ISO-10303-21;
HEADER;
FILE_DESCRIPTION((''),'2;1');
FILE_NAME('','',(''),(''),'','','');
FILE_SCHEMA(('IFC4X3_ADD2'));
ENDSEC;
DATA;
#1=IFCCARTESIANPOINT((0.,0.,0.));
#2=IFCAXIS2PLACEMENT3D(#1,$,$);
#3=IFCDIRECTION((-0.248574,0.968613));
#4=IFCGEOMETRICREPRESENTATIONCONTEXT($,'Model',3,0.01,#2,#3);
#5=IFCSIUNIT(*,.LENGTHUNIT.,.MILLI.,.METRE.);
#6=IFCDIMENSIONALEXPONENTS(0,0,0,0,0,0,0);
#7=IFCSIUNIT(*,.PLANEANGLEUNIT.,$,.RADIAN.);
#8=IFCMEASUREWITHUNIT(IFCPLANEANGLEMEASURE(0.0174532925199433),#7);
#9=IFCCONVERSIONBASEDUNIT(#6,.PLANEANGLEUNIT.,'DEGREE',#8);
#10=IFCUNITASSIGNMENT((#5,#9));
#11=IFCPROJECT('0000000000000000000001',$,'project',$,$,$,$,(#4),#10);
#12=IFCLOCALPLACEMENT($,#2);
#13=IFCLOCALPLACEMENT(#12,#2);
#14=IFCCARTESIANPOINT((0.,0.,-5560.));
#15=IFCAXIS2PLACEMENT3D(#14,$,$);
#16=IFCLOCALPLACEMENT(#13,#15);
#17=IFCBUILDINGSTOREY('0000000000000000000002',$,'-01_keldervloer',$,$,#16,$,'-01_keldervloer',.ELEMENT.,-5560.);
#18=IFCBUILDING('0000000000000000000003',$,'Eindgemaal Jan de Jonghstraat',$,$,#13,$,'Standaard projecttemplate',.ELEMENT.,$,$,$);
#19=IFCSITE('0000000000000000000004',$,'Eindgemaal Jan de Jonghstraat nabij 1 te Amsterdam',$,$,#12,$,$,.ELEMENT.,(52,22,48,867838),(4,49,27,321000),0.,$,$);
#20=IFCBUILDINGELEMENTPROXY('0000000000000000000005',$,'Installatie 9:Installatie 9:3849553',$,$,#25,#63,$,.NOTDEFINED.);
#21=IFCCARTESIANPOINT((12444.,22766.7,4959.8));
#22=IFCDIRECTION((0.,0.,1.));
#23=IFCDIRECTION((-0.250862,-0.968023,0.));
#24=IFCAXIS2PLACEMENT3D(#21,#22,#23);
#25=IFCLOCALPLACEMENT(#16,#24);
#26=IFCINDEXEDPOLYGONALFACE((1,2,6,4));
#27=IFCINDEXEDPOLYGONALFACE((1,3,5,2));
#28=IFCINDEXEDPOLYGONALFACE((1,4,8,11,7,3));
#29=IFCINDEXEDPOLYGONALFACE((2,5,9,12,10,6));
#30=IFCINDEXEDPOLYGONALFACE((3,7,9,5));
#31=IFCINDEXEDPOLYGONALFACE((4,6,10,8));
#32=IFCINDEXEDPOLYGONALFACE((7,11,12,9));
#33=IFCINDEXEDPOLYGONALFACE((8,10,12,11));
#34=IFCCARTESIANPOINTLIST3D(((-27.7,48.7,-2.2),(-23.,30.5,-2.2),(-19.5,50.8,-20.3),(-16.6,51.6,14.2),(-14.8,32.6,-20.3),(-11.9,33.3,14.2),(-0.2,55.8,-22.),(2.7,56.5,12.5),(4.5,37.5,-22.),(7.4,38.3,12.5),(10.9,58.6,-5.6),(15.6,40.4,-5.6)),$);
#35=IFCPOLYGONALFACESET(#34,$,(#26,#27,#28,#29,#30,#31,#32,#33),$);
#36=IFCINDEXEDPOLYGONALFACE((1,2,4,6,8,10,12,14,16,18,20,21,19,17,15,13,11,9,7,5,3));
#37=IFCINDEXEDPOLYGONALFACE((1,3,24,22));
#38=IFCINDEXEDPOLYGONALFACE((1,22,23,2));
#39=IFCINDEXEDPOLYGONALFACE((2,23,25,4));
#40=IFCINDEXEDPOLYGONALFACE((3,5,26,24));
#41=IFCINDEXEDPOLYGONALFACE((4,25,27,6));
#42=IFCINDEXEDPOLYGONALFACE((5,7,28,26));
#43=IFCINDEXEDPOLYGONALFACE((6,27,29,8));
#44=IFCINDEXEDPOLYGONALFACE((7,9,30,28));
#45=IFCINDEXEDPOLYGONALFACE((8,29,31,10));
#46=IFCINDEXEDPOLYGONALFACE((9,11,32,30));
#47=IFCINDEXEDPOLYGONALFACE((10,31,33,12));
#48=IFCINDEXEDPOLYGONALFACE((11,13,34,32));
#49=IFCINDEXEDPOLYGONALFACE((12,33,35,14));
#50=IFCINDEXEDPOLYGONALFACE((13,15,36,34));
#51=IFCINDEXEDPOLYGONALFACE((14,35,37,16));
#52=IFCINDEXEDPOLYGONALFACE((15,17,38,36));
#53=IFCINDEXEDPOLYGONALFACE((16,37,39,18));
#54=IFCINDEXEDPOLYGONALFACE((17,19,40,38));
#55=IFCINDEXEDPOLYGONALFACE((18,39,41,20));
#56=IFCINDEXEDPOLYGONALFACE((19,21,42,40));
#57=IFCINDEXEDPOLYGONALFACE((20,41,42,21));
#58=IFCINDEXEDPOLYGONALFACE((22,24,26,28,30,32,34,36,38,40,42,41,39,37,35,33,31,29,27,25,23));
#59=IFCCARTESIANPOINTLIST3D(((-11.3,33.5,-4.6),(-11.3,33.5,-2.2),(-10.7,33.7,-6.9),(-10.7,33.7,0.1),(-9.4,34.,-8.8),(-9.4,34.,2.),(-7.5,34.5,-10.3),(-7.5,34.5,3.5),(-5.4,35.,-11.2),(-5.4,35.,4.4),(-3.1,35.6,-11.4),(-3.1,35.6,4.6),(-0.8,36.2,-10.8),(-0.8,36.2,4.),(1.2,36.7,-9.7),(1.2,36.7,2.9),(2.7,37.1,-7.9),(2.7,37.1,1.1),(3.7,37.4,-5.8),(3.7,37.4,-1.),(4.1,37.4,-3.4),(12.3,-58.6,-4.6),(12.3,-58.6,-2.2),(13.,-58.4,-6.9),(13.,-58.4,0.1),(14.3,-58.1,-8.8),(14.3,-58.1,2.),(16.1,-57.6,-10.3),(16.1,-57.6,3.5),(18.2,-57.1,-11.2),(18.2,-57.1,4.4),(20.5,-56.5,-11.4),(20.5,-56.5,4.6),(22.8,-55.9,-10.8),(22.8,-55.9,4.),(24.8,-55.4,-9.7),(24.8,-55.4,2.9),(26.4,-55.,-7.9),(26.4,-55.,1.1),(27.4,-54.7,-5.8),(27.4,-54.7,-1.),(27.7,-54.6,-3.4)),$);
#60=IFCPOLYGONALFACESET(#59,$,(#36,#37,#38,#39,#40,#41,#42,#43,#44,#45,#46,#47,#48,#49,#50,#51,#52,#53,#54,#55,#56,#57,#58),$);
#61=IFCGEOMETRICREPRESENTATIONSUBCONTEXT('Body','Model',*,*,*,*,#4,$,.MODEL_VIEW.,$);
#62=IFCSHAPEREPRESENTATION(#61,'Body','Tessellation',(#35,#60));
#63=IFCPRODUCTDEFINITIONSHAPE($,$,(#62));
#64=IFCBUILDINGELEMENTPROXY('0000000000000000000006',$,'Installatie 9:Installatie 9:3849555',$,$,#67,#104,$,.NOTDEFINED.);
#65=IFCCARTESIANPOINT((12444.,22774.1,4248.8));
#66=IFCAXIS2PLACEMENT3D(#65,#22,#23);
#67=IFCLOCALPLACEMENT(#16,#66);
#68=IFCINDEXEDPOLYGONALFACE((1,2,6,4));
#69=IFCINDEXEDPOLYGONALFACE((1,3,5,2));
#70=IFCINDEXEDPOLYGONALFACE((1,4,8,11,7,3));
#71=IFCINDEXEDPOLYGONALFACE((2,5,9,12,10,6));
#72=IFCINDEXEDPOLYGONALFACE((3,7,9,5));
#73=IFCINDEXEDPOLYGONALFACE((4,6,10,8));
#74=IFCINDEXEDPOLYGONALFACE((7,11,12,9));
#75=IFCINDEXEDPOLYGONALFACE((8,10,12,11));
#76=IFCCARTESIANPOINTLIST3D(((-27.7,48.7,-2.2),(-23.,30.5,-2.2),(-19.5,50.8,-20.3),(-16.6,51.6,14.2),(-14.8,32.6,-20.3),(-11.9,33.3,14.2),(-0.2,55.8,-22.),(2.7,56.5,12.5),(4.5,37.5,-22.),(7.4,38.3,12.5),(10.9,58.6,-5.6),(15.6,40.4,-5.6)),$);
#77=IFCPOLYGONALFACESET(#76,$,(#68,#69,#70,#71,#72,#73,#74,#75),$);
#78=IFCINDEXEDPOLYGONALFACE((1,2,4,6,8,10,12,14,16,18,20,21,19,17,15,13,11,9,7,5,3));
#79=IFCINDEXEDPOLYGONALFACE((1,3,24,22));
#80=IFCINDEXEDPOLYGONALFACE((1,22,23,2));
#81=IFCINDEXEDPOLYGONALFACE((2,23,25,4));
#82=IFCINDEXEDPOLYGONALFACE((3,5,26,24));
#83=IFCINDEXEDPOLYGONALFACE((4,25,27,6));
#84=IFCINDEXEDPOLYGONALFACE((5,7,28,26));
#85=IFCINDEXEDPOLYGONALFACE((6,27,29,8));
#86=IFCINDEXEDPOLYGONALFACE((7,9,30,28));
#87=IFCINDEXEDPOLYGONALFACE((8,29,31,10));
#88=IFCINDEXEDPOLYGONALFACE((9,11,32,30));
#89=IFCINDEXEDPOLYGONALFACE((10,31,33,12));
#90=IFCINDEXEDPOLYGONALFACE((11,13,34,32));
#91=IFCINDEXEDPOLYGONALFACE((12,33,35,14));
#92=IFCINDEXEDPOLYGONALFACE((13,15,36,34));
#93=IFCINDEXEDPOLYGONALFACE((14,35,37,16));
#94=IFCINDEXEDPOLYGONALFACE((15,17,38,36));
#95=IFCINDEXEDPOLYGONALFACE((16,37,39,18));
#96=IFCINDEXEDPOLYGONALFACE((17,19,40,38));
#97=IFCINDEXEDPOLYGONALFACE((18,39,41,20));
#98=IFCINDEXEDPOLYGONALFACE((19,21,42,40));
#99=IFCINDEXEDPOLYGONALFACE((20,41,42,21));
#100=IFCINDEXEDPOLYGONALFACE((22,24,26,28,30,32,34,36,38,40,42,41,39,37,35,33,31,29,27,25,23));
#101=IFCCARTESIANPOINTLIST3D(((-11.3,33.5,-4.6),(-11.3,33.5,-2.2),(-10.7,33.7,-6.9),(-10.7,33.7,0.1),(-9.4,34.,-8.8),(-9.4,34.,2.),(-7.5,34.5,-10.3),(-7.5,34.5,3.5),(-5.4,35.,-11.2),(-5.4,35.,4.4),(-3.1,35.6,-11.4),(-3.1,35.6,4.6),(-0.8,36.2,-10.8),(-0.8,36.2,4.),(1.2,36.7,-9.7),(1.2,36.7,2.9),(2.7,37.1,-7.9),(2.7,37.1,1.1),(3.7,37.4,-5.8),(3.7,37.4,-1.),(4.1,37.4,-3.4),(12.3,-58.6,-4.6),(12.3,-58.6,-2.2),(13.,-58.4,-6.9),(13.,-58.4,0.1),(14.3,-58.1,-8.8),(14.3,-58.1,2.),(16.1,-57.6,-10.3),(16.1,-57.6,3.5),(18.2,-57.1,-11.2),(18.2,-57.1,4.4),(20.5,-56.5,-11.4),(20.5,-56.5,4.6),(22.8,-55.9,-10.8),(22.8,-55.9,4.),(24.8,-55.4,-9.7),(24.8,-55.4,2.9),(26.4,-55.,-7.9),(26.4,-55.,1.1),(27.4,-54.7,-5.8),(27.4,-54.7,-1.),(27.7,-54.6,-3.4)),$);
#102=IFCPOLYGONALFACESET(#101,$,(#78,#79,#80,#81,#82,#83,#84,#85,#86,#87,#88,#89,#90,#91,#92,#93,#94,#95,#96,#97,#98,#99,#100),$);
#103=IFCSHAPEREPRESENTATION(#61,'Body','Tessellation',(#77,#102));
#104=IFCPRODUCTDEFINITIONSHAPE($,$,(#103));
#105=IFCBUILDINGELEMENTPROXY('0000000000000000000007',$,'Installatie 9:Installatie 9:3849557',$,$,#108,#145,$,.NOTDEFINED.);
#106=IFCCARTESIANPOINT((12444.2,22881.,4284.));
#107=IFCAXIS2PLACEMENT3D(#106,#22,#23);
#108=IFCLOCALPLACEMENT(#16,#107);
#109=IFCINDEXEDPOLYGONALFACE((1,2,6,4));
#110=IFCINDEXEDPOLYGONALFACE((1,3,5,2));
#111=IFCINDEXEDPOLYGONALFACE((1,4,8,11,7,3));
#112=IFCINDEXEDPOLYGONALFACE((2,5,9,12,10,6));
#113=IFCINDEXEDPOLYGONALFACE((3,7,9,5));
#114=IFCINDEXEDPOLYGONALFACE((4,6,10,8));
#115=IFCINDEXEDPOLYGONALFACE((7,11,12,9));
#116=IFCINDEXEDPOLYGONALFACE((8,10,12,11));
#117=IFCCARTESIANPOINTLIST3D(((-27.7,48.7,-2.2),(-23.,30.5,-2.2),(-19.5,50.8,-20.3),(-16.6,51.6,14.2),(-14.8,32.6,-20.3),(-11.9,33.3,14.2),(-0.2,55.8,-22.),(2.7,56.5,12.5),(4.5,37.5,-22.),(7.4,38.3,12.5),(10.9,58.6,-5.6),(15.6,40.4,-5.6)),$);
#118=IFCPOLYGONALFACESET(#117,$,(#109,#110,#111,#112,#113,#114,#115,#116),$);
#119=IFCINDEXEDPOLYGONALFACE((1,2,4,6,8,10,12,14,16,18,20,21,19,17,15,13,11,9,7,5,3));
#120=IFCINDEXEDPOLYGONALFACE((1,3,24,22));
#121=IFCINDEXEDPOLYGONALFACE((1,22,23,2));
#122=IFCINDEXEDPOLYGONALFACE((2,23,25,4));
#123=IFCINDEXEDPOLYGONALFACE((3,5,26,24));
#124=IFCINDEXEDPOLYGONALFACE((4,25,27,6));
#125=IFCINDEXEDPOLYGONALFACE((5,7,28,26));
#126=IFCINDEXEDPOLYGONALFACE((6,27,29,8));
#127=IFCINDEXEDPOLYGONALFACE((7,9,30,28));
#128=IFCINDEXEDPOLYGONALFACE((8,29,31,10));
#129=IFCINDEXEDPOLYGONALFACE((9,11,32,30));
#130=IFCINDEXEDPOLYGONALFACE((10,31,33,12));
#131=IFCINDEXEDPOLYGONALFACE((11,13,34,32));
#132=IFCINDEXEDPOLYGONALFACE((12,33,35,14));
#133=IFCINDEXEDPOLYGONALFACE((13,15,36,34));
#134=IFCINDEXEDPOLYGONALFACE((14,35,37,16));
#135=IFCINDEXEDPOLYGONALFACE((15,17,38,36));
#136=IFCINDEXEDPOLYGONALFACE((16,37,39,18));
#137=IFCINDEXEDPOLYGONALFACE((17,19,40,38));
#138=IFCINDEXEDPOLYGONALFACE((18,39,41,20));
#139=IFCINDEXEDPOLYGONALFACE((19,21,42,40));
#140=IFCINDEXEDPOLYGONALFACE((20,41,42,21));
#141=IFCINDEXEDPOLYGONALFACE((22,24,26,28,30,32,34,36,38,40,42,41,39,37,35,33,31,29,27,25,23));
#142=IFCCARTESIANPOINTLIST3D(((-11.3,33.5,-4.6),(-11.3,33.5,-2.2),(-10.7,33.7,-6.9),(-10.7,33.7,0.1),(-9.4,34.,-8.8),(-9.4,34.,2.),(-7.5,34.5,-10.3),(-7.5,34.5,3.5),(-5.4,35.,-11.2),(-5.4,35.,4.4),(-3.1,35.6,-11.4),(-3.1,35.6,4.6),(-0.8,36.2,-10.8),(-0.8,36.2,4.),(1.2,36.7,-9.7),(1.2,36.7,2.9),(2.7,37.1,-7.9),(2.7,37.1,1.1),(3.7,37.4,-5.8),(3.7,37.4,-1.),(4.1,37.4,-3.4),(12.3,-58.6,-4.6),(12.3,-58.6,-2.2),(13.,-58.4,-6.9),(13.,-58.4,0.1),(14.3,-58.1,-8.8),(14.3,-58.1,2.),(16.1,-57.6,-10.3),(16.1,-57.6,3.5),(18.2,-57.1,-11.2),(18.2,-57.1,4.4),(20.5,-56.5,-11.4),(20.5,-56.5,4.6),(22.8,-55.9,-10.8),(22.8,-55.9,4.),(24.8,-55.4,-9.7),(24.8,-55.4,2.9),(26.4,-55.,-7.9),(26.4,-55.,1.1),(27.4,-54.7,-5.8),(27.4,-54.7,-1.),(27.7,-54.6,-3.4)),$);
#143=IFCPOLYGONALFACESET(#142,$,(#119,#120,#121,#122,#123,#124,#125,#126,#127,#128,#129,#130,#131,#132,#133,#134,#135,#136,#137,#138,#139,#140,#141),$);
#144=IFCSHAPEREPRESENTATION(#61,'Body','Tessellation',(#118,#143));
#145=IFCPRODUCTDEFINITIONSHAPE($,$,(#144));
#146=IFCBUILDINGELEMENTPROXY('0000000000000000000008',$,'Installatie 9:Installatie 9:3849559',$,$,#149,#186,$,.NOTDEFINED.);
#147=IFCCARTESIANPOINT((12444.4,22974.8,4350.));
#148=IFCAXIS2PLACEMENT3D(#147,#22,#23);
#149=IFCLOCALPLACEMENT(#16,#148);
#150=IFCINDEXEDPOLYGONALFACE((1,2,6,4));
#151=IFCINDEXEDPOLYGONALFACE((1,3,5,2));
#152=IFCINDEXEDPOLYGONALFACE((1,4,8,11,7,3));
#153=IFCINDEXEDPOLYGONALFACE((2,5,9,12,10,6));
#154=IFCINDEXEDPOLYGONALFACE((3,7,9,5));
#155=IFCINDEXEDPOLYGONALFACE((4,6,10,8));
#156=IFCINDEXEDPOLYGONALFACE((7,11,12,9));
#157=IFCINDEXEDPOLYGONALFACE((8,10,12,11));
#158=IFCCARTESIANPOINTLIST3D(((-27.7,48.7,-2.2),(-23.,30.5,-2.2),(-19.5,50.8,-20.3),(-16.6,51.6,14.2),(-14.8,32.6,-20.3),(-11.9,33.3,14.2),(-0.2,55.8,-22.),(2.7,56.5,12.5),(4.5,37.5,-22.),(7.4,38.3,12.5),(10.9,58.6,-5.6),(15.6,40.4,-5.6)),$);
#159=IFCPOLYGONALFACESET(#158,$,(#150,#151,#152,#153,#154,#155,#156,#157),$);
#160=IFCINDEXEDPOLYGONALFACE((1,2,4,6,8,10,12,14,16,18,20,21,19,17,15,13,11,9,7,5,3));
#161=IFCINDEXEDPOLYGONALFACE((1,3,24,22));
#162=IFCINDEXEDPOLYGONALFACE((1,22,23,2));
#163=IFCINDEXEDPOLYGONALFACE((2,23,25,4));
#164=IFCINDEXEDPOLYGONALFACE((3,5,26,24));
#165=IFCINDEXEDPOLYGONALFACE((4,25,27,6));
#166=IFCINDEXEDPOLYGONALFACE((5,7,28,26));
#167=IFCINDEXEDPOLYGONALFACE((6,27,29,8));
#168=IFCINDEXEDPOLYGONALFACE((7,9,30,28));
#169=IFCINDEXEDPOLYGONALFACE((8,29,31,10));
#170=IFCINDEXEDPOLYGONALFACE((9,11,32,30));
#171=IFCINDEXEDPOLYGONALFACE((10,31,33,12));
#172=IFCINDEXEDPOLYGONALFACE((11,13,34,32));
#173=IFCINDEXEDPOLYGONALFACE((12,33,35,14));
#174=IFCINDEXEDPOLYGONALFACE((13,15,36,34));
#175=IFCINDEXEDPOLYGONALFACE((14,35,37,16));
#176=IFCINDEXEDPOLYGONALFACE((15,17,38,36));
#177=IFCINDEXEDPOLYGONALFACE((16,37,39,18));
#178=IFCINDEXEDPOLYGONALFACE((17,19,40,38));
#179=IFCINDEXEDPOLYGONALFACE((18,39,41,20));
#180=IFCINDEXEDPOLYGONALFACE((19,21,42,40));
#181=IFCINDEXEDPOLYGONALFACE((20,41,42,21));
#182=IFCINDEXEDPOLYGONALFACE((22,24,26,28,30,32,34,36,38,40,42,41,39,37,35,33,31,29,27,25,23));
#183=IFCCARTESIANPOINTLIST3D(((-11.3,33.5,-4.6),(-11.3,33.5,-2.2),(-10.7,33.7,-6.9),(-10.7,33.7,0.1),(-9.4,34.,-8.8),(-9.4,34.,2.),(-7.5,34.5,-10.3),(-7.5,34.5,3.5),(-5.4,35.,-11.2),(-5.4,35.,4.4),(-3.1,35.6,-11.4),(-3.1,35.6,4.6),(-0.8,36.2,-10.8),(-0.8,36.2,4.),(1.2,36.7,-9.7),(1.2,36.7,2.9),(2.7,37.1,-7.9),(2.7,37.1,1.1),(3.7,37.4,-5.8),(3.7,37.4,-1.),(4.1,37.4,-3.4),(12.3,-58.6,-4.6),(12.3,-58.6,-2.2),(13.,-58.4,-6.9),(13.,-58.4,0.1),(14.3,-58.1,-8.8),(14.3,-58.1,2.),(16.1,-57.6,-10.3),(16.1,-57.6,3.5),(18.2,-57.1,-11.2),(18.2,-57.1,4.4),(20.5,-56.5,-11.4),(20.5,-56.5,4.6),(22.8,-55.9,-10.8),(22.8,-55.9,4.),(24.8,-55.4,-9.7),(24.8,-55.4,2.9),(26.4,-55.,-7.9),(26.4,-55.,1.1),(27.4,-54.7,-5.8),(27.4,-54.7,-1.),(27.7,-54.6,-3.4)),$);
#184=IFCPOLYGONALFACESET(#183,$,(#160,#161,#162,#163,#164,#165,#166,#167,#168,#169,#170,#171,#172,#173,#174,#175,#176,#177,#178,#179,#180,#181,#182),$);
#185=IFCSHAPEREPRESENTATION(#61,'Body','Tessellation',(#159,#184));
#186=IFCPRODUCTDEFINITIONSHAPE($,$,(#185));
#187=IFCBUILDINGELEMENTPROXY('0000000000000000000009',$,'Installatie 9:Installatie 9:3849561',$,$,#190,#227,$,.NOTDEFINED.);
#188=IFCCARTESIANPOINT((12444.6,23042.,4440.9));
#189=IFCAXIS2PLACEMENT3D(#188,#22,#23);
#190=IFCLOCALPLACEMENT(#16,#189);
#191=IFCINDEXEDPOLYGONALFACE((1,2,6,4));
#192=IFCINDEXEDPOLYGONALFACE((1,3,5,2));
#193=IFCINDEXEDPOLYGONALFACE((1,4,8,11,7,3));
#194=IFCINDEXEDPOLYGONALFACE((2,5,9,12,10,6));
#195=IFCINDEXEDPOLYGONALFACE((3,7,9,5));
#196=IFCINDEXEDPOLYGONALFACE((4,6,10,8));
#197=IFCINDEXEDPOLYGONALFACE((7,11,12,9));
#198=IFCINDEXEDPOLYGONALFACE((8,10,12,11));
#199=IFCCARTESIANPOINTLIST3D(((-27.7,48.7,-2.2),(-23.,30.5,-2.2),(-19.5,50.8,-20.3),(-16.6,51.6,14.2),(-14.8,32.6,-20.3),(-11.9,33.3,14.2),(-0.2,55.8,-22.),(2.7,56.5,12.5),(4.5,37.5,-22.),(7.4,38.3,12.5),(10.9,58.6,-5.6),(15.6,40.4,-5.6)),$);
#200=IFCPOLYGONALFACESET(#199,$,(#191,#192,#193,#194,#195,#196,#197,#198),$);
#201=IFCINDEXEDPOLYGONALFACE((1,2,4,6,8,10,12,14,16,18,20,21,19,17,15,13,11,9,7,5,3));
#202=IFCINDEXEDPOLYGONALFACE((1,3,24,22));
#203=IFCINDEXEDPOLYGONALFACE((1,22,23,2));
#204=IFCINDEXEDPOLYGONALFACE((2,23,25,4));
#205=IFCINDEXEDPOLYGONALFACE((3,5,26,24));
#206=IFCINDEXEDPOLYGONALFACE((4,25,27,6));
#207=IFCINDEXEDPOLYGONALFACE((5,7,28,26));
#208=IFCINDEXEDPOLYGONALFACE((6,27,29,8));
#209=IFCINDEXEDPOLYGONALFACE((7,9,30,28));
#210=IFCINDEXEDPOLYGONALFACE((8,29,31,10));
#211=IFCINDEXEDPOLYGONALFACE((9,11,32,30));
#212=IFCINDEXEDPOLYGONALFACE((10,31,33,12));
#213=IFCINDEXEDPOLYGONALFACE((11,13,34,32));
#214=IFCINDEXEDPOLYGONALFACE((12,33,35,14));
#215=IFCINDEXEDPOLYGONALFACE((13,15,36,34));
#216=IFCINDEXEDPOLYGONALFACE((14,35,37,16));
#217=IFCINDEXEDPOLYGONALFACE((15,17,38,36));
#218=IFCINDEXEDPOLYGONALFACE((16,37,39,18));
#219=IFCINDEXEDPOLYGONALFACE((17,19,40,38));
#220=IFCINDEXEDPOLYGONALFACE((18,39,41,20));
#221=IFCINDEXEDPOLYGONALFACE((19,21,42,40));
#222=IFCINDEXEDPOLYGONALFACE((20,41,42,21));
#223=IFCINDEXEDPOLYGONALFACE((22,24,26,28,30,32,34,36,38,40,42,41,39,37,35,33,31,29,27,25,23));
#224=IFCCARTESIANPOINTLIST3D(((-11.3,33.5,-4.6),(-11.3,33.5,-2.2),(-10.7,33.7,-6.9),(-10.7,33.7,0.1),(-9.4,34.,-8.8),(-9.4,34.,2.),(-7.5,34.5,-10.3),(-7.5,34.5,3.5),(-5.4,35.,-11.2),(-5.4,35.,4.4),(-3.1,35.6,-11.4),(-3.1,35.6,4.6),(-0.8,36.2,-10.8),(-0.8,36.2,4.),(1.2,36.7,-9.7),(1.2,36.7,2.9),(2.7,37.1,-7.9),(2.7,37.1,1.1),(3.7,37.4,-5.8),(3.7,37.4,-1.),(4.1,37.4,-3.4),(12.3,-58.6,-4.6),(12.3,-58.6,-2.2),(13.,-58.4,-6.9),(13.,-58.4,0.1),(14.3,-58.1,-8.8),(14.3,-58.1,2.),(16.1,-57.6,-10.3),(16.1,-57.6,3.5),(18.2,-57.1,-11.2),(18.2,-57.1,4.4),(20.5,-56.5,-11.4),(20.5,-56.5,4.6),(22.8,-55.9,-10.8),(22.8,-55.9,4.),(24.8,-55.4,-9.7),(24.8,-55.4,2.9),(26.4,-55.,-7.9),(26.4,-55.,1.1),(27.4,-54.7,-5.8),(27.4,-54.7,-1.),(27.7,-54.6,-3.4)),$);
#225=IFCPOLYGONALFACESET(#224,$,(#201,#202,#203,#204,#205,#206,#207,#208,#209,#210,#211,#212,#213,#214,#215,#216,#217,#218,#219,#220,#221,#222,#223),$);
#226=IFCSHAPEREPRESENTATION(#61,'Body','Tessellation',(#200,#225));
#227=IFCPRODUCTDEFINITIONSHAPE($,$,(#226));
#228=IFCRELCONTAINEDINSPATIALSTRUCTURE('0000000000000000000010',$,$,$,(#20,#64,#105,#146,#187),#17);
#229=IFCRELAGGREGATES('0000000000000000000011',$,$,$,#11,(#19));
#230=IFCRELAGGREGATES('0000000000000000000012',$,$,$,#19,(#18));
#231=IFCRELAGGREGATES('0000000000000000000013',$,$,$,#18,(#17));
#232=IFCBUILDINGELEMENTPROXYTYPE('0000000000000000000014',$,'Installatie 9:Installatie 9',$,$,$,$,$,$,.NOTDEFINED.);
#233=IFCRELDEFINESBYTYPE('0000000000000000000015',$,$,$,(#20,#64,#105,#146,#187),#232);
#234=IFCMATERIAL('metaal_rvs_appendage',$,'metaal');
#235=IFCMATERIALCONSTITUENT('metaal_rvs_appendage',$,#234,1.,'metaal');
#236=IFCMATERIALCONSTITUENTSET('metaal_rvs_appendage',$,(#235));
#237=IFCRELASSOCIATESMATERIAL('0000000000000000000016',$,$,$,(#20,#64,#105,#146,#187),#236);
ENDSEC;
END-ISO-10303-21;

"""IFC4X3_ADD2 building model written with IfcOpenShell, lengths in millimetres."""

from ifc_helpers import new_model, entity, si_unit, converted_unit, direction, frame, frame_2d, origin, place, context, subcontext, project, spatial, polyline, circle, outline, extrude, source, transform, mapped, material, constituent, constituent_set, type_object, type_shapes, element, save


model = new_model("IFC4X3_ADD2")

# Units and contexts
model_context = context("Model", 3, precision=0.01, world=origin(), true_north=direction((-0.248574, 0.968613)))
body_context = subcontext(model_context, "Body", "Model", "MODEL_VIEW")
ifc_project = project(units=[si_unit("LENGTHUNIT", "METRE", prefix="MILLI"), converted_unit("PLANEANGLEUNIT", "DEGREE", entity("IfcPlaneAngleMeasure", 0.0174532925199433), si_unit("PLANEANGLEUNIT", "RADIAN"), dimensions=[0, 0, 0, 0, 0, 0, 0])], contexts=[model_context])

# Site, building, storey
site_placement = place(None, origin())
site = spatial("IfcSite", under=ifc_project, at=site_placement, Name="Eindgemaal Jan de Jonghstraat nabij 1 te Amsterdam", CompositionType="ELEMENT", RefLatitude=(52, 22, 48, 867838), RefLongitude=(4, 49, 27, 321000), RefElevation=0.0)
building_placement = place(site_placement, origin())
building = spatial("IfcBuilding", under=site, at=building_placement, Name="Eindgemaal Jan de Jonghstraat", LongName="Standaard projecttemplate", CompositionType="ELEMENT")
storey_placement = place(building_placement, frame((0.0, 0.0, -5560.0)))
storey = spatial("IfcBuildingStorey", under=building, at=storey_placement, Name="-01_keldervloer", LongName="-01_keldervloer", CompositionType="ELEMENT", Elevation=-5560.0)

# Building element proxies
ifc_material_1 = material(Name="metaal_rvs_appendage", Category="metaal")
ifc_constituent_1 = constituent(ifc_material_1, Name="metaal_rvs_appendage", Category="metaal", fraction=1.0)
ifc_constituent_set_1 = constituent_set(constituents=[ifc_constituent_1], Name="metaal_rvs_appendage")
building_element_proxy_type_1 = type_object("IfcBuildingElementProxyType", Name="Installatie 9:Installatie 9", PredefinedType="NOTDEFINED")
shared_shape_1 = source(origin(), body_context, "Body", "SweptSolid", [
    extrude(outline(polyline([(-10.0, -17.3), (10.0, -17.3), (20.0, 0.0), (10.0, 17.3), (-10.0, 17.3), (-20.0, 0.0), (-10.0, -17.3)])), frame((-3.7, 35.4, -3.9), z_axis=(-0.248574, 0.968613, 0.0), x_axis=(-0.555573, -0.142576, -0.819152)), (0.0, 0.0, 1.0), 18.8),
    extrude(circle(Radius=8.0, at=frame_2d((0.0, 0.0), x_axis=(1.0, 0.0))), frame((20.0, -56.6, -3.4), z_axis=(-0.248574, 0.968613, 0.0), x_axis=(0.968613, 0.248574, 0.0)), (0.0, 0.0, 1.0), 95.1),
])
type_shapes(building_element_proxy_type_1, [shared_shape_1])
for number, where, z_axis, x_axis, name in (
    (1, (12444.0, 22766.7, 4959.8), (0.0, 0.0, 1.0), (-0.250862, -0.968023, 0.0), "Installatie 9:Installatie 9:3849553"),
    (2, (12444.0, 22774.1, 4248.8), (0.0, 0.0, 1.0), (-0.250862, -0.968023, 0.0), "Installatie 9:Installatie 9:3849555"),
    (3, (12444.2, 22881.0, 4284.0), (0.0, 0.0, 1.0), (-0.250862, -0.968023, 0.0), "Installatie 9:Installatie 9:3849557"),
    (4, (12444.4, 22974.8, 4350.0), (0.0, 0.0, 1.0), (-0.250862, -0.968023, 0.0), "Installatie 9:Installatie 9:3849559"),
    (5, (12444.6, 23042.0, 4440.9), (0.0, 0.0, 1.0), (-0.250862, -0.968023, 0.0), "Installatie 9:Installatie 9:3849561"),
):
    element("IfcBuildingElementProxy", number, at=place(storey_placement, frame(where, z_axis=z_axis, x_axis=x_axis)), inside=storey, type_object=building_element_proxy_type_1, material=ifc_constituent_set_1, Name=name, PredefinedType="NOTDEFINED", context=body_context, shape_type="MappedRepresentation", body=[
        mapped(shared_shape_1, transform((0.0, 0.0, 0.0), scale=1.0)),
    ])

save(model, "model.ifc")
